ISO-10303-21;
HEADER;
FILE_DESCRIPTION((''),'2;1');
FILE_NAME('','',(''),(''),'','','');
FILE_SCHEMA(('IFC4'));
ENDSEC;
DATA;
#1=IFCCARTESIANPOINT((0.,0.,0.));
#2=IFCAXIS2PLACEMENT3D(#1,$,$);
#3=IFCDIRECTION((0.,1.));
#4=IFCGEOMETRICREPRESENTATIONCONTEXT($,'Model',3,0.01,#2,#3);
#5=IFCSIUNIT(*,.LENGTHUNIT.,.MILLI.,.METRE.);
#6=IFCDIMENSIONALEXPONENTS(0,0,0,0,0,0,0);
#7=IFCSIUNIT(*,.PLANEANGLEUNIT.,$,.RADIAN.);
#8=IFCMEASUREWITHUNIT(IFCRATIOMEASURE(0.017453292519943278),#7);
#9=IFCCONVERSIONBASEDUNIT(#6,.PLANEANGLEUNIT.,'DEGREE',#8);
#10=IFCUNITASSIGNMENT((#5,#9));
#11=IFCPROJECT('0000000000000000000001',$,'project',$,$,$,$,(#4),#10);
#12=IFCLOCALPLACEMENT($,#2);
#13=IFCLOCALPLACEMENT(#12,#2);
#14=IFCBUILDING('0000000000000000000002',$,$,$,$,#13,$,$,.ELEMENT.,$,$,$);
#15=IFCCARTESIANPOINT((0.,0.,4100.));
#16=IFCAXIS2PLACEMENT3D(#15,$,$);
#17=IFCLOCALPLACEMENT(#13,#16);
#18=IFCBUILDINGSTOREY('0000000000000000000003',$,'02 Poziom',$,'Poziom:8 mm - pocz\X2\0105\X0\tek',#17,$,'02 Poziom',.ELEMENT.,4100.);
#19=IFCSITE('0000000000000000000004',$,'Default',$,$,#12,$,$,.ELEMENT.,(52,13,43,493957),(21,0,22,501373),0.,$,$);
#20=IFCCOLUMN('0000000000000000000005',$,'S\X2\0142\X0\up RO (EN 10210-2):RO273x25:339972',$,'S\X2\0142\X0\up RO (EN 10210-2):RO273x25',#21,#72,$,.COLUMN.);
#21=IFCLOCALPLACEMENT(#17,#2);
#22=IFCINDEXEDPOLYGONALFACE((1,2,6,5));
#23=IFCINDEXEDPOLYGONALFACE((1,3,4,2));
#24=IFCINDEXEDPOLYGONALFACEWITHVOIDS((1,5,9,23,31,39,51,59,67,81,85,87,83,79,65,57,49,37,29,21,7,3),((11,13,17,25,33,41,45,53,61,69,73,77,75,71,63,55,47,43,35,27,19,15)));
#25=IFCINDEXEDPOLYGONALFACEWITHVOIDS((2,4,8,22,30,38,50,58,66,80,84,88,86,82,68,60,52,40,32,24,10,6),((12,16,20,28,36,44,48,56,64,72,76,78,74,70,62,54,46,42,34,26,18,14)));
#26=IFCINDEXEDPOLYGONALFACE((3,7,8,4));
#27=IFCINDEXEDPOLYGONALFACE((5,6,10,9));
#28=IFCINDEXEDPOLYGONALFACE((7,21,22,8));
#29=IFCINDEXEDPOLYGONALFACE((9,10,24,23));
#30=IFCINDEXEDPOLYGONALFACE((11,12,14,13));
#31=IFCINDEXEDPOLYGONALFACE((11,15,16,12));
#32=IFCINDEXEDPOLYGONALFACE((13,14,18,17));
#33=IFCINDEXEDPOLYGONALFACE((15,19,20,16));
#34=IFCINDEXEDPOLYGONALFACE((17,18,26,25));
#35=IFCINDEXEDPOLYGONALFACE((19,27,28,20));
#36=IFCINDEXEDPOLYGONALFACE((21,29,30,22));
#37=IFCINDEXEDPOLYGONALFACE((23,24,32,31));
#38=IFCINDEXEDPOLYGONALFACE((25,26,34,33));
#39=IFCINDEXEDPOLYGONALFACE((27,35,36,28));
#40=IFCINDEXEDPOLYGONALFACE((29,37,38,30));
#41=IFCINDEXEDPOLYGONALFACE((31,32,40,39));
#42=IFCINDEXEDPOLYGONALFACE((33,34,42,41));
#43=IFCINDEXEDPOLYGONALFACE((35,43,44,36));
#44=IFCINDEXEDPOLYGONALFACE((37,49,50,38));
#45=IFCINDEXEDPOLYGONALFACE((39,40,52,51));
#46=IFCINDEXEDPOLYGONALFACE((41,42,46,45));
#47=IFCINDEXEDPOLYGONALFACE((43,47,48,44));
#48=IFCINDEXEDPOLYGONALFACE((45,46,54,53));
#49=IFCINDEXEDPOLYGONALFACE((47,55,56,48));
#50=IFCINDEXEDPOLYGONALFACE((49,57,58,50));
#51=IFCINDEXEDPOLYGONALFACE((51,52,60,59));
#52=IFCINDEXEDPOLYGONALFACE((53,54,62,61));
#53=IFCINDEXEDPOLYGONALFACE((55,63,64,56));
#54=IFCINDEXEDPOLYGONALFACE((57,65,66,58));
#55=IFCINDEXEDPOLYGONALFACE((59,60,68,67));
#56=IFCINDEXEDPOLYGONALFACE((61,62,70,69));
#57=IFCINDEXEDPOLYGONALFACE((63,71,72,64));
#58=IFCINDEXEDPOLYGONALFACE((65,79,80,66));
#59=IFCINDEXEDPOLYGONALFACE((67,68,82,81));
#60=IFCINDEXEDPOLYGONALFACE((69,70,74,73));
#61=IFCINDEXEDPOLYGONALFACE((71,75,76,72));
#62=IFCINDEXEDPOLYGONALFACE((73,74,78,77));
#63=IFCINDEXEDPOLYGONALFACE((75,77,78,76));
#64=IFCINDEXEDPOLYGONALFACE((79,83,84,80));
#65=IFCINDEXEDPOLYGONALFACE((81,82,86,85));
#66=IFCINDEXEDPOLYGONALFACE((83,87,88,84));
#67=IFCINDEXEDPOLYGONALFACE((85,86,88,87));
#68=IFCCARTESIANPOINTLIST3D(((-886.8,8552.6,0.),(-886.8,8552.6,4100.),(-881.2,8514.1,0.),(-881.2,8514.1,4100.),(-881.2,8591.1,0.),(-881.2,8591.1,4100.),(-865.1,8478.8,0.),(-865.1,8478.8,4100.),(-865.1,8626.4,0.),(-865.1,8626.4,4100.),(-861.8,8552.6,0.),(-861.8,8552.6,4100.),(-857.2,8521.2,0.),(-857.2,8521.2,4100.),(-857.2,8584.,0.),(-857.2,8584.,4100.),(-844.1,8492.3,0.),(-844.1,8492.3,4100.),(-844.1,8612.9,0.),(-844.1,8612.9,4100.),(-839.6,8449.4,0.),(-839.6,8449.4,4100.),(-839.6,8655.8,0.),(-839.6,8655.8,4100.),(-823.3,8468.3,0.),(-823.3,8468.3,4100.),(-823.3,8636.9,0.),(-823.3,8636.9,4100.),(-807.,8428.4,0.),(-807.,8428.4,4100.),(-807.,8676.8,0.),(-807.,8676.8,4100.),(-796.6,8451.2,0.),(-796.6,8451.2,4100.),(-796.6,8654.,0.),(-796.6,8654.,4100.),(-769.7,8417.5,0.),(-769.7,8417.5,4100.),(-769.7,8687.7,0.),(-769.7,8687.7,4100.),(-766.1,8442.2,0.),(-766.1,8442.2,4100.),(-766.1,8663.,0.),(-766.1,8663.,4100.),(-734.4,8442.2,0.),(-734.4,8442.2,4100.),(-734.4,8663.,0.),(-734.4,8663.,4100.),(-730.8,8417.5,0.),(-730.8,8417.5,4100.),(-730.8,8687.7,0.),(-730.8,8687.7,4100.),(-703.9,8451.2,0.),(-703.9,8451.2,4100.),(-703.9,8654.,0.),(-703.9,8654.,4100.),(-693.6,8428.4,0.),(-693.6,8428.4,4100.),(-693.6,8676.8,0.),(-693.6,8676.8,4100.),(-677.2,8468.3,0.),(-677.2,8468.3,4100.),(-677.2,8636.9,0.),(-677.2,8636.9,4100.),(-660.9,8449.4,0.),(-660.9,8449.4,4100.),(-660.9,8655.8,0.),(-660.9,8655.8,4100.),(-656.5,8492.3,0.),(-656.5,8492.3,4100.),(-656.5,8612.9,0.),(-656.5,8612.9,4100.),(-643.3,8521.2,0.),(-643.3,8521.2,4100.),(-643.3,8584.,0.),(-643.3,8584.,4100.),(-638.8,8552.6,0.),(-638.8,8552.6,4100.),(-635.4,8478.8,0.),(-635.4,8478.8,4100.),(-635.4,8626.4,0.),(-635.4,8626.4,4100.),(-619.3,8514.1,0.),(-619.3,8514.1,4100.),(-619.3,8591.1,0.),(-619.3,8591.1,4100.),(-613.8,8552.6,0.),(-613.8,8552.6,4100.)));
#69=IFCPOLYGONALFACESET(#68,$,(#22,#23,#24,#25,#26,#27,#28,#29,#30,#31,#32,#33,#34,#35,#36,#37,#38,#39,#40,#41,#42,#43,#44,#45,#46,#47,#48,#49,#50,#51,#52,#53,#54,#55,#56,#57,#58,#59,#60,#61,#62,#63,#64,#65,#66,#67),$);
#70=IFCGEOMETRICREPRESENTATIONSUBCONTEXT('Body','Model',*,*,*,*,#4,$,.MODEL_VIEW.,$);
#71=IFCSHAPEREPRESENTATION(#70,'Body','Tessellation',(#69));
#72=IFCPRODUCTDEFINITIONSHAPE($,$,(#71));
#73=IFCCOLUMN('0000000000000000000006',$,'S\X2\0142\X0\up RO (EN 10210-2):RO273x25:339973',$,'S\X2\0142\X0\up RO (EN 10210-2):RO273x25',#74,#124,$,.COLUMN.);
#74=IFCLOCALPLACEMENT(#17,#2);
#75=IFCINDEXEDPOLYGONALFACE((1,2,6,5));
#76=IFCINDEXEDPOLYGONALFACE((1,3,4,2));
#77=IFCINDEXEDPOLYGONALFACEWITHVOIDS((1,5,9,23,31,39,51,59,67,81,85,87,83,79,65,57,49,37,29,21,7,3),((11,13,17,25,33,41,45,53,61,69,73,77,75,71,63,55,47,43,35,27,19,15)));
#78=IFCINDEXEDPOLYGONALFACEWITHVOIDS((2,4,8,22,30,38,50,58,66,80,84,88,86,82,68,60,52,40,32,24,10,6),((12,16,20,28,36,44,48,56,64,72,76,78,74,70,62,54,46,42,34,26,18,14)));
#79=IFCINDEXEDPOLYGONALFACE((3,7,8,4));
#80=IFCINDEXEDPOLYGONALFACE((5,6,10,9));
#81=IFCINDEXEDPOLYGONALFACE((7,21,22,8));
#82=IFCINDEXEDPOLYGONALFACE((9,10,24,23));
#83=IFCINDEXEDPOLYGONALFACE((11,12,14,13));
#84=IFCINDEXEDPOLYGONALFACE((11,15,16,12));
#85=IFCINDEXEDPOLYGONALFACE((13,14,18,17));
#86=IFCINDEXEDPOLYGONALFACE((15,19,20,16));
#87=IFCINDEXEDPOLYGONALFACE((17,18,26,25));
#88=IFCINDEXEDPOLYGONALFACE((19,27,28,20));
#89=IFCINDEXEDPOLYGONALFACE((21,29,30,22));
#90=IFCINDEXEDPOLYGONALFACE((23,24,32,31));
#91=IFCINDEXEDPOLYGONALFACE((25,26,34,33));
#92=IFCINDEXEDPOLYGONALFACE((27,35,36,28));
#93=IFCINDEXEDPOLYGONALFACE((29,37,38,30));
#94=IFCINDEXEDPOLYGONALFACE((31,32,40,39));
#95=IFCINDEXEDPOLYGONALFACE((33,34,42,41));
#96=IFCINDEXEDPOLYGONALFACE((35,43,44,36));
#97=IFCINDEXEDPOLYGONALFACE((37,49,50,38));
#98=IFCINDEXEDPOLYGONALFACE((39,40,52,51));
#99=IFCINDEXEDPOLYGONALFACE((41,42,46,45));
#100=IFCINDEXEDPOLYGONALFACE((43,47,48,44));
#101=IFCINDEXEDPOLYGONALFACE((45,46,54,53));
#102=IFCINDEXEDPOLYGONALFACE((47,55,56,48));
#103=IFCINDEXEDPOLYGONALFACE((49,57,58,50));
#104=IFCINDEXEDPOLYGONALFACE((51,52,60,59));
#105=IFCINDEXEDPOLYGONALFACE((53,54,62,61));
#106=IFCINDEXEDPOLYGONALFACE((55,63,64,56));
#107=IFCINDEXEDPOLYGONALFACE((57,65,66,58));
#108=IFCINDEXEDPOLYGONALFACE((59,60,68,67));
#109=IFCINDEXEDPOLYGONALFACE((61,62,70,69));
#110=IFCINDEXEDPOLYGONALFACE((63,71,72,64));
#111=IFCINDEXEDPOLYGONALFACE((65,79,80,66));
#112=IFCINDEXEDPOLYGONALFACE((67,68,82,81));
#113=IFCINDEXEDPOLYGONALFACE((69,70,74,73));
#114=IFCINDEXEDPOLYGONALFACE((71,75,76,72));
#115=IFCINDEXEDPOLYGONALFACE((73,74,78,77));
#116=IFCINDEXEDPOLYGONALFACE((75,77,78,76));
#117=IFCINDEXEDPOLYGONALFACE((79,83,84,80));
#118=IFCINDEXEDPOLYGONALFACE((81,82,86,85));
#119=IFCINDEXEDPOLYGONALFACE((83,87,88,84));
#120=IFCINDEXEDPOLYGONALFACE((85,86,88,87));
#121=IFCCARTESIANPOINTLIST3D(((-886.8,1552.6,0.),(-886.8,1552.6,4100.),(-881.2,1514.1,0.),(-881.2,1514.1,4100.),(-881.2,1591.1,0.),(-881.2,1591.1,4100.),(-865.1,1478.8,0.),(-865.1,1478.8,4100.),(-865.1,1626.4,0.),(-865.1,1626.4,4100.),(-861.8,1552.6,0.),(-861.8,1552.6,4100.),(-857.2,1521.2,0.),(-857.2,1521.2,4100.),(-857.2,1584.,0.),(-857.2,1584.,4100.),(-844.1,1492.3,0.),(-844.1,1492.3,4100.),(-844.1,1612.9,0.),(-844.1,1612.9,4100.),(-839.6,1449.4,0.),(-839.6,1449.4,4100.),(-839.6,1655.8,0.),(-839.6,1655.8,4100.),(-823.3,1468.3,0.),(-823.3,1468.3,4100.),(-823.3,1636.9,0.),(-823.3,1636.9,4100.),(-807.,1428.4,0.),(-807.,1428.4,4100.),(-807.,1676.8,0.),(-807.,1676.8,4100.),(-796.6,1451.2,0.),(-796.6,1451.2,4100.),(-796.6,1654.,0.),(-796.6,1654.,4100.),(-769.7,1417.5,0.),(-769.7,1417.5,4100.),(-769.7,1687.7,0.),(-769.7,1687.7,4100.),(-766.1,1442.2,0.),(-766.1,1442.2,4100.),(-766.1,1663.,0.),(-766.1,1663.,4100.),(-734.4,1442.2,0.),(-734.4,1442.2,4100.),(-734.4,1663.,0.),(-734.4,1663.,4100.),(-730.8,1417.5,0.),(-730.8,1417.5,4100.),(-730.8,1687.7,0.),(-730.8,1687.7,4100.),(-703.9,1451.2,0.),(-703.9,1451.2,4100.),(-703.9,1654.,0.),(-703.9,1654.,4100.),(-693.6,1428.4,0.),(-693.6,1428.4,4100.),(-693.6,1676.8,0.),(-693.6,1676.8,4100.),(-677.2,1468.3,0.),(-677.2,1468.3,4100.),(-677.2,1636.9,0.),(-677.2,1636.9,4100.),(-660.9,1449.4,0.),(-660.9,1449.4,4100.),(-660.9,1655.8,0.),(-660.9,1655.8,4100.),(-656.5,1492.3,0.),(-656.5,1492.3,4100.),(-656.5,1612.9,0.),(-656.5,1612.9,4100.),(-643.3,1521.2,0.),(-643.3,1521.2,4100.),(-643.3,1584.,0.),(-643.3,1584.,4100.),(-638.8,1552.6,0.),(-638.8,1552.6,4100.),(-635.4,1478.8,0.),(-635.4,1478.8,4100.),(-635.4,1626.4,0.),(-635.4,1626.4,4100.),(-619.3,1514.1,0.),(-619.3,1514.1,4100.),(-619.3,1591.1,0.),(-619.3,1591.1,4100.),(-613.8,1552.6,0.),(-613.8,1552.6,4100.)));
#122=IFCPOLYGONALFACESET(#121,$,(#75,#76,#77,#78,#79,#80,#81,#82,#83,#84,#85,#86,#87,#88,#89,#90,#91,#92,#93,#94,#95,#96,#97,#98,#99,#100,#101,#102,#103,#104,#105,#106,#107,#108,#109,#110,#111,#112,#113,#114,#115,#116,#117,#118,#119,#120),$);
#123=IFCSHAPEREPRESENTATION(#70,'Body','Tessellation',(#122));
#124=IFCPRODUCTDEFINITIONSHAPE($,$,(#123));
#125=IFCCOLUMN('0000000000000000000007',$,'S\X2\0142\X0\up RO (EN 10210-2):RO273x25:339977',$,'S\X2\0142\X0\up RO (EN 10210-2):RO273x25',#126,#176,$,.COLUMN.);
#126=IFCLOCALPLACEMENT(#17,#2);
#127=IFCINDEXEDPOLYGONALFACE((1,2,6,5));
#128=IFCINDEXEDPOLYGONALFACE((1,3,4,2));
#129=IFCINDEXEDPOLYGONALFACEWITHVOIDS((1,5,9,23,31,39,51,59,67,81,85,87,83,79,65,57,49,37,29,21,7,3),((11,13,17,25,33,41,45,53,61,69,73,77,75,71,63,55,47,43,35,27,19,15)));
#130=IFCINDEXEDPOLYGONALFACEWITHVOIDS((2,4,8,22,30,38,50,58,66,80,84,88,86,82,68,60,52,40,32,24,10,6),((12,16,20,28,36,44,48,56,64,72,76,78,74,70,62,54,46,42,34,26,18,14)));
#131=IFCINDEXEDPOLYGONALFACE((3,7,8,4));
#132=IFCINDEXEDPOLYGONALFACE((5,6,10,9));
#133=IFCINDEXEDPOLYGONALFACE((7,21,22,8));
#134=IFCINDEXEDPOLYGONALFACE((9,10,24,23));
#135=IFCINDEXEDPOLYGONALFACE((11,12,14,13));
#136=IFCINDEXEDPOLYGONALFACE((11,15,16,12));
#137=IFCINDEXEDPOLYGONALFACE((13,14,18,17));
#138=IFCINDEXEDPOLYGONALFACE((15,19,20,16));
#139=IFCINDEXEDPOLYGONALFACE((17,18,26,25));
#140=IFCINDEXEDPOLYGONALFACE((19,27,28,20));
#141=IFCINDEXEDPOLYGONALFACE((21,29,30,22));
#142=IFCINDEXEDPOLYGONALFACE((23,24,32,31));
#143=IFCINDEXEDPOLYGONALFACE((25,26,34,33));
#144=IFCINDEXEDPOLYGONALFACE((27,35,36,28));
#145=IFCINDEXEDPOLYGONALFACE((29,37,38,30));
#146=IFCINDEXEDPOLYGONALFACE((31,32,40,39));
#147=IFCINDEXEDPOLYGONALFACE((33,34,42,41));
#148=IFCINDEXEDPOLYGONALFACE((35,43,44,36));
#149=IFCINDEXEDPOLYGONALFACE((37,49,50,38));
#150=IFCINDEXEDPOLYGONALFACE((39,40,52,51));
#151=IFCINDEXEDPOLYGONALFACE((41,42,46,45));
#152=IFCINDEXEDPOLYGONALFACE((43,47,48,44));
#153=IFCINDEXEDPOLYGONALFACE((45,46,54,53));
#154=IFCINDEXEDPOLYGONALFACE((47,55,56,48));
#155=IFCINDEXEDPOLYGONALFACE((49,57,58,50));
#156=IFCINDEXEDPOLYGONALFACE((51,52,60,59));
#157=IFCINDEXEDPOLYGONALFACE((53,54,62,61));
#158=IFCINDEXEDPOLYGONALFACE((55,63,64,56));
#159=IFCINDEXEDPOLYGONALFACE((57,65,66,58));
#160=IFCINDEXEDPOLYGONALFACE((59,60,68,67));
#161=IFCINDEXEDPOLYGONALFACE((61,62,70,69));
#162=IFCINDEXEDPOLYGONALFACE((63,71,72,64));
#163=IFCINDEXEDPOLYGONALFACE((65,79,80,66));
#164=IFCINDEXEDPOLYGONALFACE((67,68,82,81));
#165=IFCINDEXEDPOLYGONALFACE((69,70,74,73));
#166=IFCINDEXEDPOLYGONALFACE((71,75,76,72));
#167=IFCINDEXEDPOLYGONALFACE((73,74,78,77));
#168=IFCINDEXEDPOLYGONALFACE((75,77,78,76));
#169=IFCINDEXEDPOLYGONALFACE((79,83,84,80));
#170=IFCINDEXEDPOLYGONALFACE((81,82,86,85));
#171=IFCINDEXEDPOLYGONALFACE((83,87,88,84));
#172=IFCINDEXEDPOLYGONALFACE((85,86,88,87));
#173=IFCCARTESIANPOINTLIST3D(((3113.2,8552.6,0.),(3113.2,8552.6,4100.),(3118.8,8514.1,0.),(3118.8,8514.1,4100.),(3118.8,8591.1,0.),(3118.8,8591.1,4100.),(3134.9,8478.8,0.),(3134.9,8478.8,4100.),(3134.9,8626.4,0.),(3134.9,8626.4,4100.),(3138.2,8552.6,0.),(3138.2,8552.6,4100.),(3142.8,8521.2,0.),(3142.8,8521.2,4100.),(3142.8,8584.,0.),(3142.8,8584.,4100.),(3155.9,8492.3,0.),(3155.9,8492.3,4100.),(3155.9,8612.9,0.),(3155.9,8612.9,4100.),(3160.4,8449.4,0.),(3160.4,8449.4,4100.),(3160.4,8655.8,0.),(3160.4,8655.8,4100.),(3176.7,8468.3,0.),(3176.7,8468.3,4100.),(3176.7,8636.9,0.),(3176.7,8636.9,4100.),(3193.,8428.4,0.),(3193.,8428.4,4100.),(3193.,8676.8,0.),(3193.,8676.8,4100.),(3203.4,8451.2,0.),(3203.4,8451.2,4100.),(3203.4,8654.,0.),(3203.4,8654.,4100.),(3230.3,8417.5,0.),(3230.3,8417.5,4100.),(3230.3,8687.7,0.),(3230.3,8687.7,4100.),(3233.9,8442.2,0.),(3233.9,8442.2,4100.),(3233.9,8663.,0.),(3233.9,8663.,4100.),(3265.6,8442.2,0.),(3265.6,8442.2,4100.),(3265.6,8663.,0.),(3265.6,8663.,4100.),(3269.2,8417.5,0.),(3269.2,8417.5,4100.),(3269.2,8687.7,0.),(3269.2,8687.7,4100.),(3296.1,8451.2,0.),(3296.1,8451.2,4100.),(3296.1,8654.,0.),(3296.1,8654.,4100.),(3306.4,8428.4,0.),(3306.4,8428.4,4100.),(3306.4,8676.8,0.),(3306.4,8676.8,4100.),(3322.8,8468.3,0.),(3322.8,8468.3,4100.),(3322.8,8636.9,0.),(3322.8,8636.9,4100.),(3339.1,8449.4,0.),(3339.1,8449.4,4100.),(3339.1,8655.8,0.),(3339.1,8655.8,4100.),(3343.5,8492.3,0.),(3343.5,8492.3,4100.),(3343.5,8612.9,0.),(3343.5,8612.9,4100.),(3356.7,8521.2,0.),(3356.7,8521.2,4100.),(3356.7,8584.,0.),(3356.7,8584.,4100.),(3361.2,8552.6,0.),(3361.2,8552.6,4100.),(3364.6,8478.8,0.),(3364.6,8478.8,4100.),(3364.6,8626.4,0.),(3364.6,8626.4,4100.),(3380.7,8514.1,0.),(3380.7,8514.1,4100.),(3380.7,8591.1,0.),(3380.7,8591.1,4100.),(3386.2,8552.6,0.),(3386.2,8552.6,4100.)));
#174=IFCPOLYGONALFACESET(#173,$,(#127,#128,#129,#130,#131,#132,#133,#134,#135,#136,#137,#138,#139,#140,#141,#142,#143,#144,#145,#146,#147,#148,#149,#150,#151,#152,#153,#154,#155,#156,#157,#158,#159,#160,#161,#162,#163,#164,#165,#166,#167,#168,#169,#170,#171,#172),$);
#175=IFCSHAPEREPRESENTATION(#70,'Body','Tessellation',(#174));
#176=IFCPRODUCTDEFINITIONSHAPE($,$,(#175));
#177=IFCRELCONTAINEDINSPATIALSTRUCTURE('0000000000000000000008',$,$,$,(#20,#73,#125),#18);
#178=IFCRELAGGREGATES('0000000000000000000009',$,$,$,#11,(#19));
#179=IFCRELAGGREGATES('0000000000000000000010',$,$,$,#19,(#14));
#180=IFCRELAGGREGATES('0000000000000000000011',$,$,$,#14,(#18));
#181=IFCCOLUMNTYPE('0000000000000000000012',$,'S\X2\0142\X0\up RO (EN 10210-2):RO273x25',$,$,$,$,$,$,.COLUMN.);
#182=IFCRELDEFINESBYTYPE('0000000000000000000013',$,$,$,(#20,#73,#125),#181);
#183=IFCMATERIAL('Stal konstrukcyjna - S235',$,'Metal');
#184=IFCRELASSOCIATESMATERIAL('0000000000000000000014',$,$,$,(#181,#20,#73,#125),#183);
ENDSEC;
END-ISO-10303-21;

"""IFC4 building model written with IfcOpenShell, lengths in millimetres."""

from ifc_helpers import new_model, entity, si_unit, converted_unit, direction, frame, origin, place, context, subcontext, project, spatial, arc, indexed_curve, outline, extrude, source, transform, mapped, material, type_object, type_shapes, element, save


model = new_model("IFC4")

# Units and contexts
model_context = context("Model", 3, precision=0.01, world=origin(), true_north=direction((0.0, 1.0)))
body_context = subcontext(model_context, "Body", "Model", "MODEL_VIEW")
ifc_project = project(units=[si_unit("LENGTHUNIT", "METRE", prefix="MILLI"), converted_unit("PLANEANGLEUNIT", "DEGREE", entity("IfcRatioMeasure", 0.017453292519943278), si_unit("PLANEANGLEUNIT", "RADIAN"), dimensions=[0, 0, 0, 0, 0, 0, 0])], contexts=[model_context])

# Site, building, storey
site_placement = place(None, origin())
site = spatial("IfcSite", under=ifc_project, at=site_placement, Name="Default", CompositionType="ELEMENT", RefLatitude=(52, 13, 43, 493957), RefLongitude=(21, 0, 22, 501373), RefElevation=0.0)
building_placement = place(site_placement, origin())
building = spatial("IfcBuilding", under=site, at=building_placement, CompositionType="ELEMENT")
storey_placement = place(building_placement, frame((0.0, 0.0, 4100.0)))
storey = spatial("IfcBuildingStorey", under=building, at=storey_placement, Name="02 Poziom", ObjectType="Poziom:8 mm - początek", LongName="02 Poziom", CompositionType="ELEMENT", Elevation=4100.0)

# Columns
ifc_material_1 = material(Name="Stal konstrukcyjna - S235", Category="Metal")
column_type = type_object("IfcColumnType", Name="Słup RO (EN 10210-2):RO273x25", PredefinedType="COLUMN", material=ifc_material_1)
shared_shape_1 = source(origin(), body_context, "Body", "SweptSolid", [
    extrude(outline(indexed_curve([(-136.5, 0.0), (0.0, -136.5), (136.5, 0.0), (0.0, 136.5)], segments=[arc(1, 2, 3), arc(3, 4, 1)], self_intersect=False), holes=[indexed_curve([(-111.5, 0.0), (0.0, 111.5), (111.5, 0.0), (0.0, -111.5)], segments=[arc(1, 2, 3), arc(3, 4, 1)], self_intersect=False)]), frame((0.0, 0.0, 4100.0)), (0.0, 0.0, 1.0), 4100.0),
])
type_shapes(column_type, [shared_shape_1])
for number, where, name in (
    (1, (-750.3, 8552.6, -4100.0), "Słup RO (EN 10210-2):RO273x25:339972"),
    (2, (-750.3, 1552.6, -4100.0), "Słup RO (EN 10210-2):RO273x25:339973"),
    (3, (3249.7, 8552.6, -4100.0), "Słup RO (EN 10210-2):RO273x25:339977"),
):
    element("IfcColumn", number, at=place(storey_placement, frame(where)), inside=storey, type_object=column_type, material=ifc_material_1, Name=name, ObjectType="Słup RO (EN 10210-2):RO273x25", PredefinedType="COLUMN", context=body_context, shape_type="MappedRepresentation", body=[
        mapped(shared_shape_1, transform((0.0, 0.0, 0.0), scale=1.0)),
    ])

save(model, "model.ifc")
